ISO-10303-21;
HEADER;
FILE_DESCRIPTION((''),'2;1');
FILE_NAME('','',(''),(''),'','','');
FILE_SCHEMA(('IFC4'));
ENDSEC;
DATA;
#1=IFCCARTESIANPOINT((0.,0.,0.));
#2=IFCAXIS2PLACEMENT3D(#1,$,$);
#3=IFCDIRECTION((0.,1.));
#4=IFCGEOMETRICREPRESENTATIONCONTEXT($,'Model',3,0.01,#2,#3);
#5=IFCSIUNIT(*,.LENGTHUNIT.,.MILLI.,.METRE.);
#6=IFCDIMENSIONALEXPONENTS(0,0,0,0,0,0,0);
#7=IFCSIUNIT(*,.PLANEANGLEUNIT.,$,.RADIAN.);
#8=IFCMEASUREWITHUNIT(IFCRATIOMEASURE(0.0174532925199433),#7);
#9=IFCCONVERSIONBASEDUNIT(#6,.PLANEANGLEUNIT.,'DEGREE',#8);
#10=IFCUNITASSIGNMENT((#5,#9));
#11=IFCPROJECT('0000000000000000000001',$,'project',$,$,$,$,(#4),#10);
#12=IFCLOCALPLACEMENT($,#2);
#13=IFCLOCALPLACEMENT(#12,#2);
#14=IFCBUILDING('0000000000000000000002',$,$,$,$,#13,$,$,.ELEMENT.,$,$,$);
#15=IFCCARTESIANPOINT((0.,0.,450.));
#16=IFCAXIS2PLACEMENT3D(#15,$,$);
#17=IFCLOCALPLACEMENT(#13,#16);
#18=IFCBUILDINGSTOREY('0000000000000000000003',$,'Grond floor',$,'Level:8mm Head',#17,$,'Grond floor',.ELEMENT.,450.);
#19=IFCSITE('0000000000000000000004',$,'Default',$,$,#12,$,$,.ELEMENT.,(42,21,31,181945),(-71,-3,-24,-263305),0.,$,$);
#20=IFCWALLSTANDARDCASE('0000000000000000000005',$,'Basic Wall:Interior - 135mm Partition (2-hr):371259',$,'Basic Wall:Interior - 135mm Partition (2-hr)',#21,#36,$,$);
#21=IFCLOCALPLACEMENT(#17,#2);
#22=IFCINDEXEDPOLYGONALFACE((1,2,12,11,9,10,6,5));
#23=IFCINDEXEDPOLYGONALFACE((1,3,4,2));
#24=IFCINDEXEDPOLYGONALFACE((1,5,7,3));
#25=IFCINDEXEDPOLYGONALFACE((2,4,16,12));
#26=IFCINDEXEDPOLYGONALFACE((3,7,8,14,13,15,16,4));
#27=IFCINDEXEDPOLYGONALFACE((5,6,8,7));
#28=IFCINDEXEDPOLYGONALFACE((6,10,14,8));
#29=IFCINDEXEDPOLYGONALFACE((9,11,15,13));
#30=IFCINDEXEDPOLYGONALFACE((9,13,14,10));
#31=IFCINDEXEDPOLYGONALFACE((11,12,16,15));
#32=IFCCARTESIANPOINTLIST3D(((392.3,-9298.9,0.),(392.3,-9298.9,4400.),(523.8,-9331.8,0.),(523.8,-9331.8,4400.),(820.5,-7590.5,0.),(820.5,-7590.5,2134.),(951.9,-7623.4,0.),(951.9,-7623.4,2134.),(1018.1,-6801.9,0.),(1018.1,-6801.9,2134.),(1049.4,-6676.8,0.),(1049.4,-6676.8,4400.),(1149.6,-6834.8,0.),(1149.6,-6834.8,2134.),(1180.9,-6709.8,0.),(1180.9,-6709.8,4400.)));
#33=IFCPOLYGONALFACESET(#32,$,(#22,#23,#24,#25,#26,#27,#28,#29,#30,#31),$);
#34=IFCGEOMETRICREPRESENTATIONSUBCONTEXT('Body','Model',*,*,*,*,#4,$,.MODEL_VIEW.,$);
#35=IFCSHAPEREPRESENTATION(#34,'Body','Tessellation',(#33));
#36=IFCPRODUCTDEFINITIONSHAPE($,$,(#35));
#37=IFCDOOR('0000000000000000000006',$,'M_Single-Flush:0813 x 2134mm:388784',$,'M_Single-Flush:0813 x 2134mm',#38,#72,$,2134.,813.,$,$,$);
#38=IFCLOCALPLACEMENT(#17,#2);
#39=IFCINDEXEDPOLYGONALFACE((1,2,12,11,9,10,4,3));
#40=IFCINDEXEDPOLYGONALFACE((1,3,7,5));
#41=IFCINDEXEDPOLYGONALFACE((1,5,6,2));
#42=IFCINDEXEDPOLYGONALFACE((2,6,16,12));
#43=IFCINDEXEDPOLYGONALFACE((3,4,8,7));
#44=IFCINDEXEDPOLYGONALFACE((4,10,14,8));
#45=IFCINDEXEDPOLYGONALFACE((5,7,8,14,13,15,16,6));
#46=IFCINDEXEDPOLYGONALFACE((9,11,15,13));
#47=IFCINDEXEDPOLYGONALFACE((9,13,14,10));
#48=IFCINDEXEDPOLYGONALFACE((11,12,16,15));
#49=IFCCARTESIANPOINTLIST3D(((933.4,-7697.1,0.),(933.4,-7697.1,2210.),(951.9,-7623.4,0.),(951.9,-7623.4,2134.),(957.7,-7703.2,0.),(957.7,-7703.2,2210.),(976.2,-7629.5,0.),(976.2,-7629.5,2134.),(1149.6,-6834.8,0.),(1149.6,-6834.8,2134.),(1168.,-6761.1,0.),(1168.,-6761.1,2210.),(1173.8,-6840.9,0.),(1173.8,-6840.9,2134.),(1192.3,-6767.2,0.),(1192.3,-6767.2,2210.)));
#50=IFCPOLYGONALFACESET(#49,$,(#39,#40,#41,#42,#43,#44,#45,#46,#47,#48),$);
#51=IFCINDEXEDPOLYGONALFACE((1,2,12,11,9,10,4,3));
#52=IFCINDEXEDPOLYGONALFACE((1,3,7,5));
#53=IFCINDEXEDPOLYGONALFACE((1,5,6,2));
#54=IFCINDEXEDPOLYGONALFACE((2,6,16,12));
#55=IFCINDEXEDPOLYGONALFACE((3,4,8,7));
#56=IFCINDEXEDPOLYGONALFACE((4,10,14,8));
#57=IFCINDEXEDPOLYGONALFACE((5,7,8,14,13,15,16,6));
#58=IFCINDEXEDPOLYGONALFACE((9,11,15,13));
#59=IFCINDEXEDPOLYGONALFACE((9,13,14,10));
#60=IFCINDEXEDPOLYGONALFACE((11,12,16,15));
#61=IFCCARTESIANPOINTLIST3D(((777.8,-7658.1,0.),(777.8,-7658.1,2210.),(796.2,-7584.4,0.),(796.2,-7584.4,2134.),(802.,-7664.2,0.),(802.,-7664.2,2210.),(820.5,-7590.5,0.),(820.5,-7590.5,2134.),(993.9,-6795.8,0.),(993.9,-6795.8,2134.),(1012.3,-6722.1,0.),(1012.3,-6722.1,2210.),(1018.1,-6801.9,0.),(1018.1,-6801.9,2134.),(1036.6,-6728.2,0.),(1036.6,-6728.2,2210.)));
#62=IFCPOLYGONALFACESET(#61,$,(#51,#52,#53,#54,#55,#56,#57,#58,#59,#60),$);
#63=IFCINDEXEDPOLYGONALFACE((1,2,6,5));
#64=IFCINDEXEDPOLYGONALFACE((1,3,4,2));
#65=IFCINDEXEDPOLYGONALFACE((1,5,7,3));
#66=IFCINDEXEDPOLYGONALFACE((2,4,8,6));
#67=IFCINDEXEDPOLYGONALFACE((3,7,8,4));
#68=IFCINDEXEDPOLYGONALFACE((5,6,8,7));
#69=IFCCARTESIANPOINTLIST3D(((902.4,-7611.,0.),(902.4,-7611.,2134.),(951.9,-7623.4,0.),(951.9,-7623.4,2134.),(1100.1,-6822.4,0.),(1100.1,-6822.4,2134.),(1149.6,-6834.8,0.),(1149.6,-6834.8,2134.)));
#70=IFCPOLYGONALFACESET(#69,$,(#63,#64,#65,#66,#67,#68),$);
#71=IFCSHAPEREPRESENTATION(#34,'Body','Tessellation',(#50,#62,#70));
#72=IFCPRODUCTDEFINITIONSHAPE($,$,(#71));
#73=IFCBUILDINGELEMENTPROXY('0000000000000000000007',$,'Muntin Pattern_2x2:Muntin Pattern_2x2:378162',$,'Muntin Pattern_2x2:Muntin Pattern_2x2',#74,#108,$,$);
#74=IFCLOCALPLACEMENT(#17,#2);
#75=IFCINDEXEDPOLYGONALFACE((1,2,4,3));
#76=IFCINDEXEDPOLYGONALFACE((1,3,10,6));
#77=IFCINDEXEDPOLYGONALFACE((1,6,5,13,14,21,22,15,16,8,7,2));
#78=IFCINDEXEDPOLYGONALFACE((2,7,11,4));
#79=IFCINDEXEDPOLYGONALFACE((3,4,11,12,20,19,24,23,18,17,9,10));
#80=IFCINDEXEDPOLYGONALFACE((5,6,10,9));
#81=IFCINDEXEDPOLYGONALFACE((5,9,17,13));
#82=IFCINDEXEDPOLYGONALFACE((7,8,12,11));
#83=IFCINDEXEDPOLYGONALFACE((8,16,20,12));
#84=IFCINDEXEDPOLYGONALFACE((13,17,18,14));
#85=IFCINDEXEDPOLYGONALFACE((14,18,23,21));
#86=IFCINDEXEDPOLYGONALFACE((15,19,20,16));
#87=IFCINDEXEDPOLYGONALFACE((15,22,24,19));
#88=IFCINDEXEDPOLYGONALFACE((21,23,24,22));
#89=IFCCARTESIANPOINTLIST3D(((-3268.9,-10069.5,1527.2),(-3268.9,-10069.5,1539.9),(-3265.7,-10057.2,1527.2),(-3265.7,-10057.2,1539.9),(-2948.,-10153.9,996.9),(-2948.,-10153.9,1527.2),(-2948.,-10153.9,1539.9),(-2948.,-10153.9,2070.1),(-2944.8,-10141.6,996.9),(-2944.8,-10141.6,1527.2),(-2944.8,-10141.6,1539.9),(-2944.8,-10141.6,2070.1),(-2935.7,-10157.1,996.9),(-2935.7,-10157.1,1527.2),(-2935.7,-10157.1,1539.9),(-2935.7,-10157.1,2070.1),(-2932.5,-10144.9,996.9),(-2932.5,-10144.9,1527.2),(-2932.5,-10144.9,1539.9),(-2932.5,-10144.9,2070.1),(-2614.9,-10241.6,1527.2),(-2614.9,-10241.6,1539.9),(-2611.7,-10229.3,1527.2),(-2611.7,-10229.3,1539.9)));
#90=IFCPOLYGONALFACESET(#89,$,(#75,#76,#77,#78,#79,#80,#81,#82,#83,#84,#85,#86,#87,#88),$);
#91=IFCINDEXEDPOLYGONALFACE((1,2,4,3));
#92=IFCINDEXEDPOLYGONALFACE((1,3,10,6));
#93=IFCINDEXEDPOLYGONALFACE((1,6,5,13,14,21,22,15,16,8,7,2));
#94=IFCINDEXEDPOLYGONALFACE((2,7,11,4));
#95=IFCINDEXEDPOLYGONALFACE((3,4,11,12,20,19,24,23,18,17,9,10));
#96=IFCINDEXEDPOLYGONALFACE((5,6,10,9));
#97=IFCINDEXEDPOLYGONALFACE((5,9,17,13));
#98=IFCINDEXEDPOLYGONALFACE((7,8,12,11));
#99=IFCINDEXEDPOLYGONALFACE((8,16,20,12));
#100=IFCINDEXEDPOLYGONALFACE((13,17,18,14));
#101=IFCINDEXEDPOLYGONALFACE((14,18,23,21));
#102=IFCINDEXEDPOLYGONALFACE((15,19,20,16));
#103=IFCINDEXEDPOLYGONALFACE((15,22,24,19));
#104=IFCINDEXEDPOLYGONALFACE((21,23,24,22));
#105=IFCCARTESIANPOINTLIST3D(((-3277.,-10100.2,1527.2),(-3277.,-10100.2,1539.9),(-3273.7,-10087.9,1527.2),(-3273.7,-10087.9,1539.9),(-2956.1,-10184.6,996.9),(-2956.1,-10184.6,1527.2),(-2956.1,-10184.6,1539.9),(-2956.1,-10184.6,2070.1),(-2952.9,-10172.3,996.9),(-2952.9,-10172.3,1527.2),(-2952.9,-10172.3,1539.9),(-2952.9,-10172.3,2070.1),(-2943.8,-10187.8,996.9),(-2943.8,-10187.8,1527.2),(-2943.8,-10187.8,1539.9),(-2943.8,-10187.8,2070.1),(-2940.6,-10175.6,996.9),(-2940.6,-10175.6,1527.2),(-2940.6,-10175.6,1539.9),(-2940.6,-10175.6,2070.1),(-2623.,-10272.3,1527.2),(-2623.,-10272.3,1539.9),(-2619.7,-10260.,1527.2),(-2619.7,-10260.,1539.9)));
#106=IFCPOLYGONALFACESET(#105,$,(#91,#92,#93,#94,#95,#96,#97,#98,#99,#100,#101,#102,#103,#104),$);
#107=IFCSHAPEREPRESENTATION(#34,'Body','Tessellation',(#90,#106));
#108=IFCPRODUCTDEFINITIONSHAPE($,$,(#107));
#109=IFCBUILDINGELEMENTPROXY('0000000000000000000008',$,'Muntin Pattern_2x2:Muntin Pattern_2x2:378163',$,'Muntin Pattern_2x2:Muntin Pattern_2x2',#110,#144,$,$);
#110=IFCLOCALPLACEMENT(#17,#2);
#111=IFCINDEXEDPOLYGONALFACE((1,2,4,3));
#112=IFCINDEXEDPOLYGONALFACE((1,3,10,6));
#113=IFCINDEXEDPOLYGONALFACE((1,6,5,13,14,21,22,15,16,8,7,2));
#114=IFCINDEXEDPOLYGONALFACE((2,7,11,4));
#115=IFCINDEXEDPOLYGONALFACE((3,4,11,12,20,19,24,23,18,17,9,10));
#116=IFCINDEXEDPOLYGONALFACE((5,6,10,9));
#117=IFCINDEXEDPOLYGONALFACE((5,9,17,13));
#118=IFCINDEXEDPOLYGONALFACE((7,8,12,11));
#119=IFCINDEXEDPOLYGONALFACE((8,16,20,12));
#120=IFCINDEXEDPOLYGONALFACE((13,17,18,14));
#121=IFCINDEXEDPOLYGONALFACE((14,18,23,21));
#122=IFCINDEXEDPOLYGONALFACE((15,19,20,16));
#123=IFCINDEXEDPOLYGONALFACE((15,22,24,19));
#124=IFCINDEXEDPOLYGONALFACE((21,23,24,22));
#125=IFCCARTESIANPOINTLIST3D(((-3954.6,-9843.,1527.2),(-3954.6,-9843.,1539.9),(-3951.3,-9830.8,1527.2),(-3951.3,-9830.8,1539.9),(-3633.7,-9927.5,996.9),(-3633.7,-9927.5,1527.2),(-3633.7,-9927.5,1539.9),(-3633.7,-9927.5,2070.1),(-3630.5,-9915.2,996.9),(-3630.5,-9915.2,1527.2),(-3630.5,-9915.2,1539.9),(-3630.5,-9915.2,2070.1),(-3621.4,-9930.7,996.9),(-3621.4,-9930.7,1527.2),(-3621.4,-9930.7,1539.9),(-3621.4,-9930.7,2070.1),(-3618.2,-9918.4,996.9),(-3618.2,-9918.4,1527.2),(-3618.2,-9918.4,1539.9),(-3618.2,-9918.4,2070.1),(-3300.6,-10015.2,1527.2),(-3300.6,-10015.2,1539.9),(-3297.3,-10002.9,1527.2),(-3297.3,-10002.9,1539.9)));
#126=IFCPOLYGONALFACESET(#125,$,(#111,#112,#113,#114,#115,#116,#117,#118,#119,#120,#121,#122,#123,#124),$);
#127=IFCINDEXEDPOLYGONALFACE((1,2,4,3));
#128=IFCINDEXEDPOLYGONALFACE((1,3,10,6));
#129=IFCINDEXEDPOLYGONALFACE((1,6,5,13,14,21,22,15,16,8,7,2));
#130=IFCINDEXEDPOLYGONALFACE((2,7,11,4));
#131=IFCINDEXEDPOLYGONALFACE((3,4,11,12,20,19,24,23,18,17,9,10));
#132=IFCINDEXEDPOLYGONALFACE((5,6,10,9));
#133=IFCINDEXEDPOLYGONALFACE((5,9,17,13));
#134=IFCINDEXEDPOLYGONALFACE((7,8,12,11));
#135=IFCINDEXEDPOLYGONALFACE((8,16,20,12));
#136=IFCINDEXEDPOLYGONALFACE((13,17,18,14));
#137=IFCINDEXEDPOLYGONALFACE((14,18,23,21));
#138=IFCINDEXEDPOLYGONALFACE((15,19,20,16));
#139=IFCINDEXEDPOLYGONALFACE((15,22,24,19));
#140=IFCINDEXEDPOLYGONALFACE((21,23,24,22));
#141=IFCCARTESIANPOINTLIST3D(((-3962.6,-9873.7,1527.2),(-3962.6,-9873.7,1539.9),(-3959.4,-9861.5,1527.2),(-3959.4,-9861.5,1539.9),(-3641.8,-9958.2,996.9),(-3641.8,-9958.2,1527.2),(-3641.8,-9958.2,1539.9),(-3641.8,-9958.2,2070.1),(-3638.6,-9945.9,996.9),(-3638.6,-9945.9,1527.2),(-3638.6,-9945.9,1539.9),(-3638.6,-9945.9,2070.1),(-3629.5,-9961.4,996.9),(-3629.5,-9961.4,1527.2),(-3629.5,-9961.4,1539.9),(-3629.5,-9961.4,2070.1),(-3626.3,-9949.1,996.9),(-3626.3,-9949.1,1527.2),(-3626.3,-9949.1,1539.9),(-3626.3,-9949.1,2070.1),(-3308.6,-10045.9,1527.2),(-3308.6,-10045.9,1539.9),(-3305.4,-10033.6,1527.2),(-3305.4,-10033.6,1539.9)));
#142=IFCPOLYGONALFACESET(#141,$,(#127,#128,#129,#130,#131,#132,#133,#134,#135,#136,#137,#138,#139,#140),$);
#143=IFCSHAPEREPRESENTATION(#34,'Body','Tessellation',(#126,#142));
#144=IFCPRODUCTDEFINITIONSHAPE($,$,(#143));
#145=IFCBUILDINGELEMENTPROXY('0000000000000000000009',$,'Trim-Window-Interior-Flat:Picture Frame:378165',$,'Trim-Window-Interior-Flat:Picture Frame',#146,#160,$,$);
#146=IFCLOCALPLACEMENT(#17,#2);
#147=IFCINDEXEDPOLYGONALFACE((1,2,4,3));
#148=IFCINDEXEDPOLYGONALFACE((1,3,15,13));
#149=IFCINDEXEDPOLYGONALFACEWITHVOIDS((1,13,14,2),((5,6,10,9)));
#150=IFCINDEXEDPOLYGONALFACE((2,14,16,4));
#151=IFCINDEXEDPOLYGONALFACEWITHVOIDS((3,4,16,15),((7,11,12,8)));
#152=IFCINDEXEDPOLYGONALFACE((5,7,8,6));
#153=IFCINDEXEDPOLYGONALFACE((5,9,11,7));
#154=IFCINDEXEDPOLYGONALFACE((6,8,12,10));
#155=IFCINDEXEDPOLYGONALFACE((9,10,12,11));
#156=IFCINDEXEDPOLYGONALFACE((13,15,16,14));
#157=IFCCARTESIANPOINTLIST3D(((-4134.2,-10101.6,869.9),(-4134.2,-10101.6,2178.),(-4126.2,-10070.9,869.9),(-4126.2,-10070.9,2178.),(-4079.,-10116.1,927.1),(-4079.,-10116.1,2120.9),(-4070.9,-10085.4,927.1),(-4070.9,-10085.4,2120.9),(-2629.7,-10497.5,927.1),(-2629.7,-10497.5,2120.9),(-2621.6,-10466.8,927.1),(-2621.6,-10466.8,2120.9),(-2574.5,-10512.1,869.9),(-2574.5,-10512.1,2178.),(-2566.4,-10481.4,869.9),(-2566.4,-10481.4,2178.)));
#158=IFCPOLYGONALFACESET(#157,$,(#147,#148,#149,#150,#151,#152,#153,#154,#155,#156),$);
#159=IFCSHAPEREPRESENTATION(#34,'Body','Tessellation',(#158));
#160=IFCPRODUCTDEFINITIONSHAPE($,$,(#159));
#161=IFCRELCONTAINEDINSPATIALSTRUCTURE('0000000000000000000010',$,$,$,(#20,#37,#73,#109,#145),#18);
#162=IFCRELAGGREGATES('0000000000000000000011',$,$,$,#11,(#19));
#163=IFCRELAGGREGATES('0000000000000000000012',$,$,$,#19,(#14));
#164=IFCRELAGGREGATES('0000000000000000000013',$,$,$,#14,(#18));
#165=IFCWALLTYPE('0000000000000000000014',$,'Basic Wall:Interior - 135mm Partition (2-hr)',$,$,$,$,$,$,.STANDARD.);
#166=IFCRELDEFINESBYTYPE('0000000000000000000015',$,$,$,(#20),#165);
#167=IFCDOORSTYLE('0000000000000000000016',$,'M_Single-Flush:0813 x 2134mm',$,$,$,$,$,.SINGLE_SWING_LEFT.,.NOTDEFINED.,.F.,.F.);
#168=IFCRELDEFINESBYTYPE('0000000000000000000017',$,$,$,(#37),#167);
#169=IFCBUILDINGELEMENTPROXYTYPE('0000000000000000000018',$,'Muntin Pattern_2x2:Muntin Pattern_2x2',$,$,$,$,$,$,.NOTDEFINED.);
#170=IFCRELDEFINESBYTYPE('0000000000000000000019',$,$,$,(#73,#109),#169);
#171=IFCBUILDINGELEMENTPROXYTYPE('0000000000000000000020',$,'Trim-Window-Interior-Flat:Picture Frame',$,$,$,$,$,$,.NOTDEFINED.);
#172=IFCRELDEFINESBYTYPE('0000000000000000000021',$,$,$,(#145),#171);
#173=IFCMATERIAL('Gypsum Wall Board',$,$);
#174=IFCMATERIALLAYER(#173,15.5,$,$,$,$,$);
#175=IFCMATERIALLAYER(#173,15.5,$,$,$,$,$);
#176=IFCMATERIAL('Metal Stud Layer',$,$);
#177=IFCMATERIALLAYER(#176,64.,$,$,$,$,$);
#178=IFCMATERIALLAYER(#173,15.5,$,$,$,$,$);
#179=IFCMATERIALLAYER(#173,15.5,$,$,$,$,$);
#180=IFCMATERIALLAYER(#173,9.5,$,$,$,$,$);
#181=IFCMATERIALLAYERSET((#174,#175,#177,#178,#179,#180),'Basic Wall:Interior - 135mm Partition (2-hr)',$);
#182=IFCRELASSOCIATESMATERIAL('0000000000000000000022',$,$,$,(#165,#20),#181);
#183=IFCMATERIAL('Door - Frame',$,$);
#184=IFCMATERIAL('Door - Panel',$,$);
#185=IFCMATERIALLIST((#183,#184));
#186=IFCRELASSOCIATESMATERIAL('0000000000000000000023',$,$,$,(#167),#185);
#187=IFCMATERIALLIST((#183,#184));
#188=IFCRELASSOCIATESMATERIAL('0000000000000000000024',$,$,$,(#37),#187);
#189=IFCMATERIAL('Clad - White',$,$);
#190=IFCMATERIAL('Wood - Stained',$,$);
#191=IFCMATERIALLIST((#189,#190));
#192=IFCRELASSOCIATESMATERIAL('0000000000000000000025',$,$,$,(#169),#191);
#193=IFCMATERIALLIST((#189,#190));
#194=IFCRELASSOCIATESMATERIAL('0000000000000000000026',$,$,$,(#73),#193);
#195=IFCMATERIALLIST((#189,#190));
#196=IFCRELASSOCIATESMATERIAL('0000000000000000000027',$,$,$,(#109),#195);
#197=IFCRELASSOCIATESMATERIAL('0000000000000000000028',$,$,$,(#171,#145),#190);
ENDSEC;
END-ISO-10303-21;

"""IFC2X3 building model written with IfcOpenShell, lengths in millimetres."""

from ifc_helpers import new_model, entity, si_unit, converted_unit, direction, frame, frame_2d, origin, place, context, subcontext, project, spatial, polyline, rectangle, outline, extrude, source, transform, mapped, material, material_list, layer, layer_set, layer_usage, type_object, type_shapes, element, fill, save


model = new_model("IFC2X3")

# Units and contexts
model_context = context("Model", 3, precision=0.01, world=origin(), true_north=direction((0.0, 1.0)))
body_context = subcontext(model_context, "Body", "Model", "MODEL_VIEW")
ifc_project = project(units=[si_unit("LENGTHUNIT", "METRE", prefix="MILLI"), converted_unit("PLANEANGLEUNIT", "DEGREE", entity("IfcRatioMeasure", 0.0174532925199433), si_unit("PLANEANGLEUNIT", "RADIAN"), dimensions=[0, 0, 0, 0, 0, 0, 0])], contexts=[model_context])

# Site, building, storey
site_placement = place(None, origin())
site = spatial("IfcSite", under=ifc_project, at=site_placement, Name="Default", CompositionType="ELEMENT", RefLatitude=(42, 21, 31, 181945), RefLongitude=(-71, -3, -24, -263305), RefElevation=0.0)
building_placement = place(site_placement, origin())
building = spatial("IfcBuilding", under=site, at=building_placement, CompositionType="ELEMENT")
storey_placement = place(building_placement, frame((0.0, 0.0, 450.0)))
storey = spatial("IfcBuildingStorey", under=building, at=storey_placement, Name="Grond floor", ObjectType="Level:8mm Head", LongName="Grond floor", CompositionType="ELEMENT", Elevation=450.0)

# Shared definitions
ifc_material_1 = material(Name="Gypsum Wall Board")
ifc_layer_1 = layer(ifc_material_1, 15.5)
ifc_layer_2 = layer(ifc_material_1, 15.5)
ifc_material_2 = material(Name="Metal Stud Layer")
ifc_layer_3 = layer(ifc_material_2, 64.0)
ifc_layer_4 = layer(ifc_material_1, 15.5)
ifc_layer_5 = layer(ifc_material_1, 15.5)
ifc_layer_6 = layer(ifc_material_1, 9.5)
ifc_layer_set = layer_set([ifc_layer_1, ifc_layer_2, ifc_layer_3, ifc_layer_4, ifc_layer_5, ifc_layer_6], Name="Basic Wall:Interior - 135mm Partition (2-hr)")
wall_type = type_object("IfcWallType", Name="Basic Wall:Interior - 135mm Partition (2-hr)", PredefinedType="STANDARD", material=ifc_layer_set)

# Shared definitions
ifc_material_3 = material(Name="Door - Frame")
ifc_material_4 = material(Name="Door - Panel")

# Wall, opening, door
ifc_layer_usage_1 = layer_usage(ifc_layer_set, "AXIS2", "NEGATIVE", 67.8)
wall_1_placement = place(storey_placement, frame((458.1, -9315.4, 0.0), z_axis=(0.0, 0.0, 1.0), x_axis=(0.243092, 0.970003, 0.0)))
wall_1 = element("IfcWallStandardCase", 1, at=wall_1_placement, inside=storey, type_object=wall_type, material=ifc_layer_usage_1, Name="Basic Wall:Interior - 135mm Partition (2-hr):371259", ObjectType="Basic Wall:Interior - 135mm Partition (2-hr)", context=body_context, shape_type="SweptSolid", body=[
    extrude(rectangle(XDim=2703.1, YDim=135.5, at=frame_2d((1351.6, 0.0), x_axis=(-1.0, 0.0))), origin(), (0.0, 0.0, 1.0), 4400.0),
])
opening_1_placement = place(wall_1_placement, frame((2574.2, 67.8, 0.0)))
opening_1 = element("IfcOpeningElement", 2, at=opening_1_placement, cuts=wall_1, ObjectType="Opening", context=body_context, shape_type="SweptSolid", body=[
    extrude(rectangle(XDim=813.0, YDim=2134.0, at=frame_2d((1067.0, 406.5), x_axis=(0.0, -1.0))), frame((0.0, 0.0, 0.0), z_axis=(0.0, -1.0, 0.0), x_axis=(0.0, 0.0, 1.0)), (0.0, 0.0, 1.0), 135.5),
])
ifc_material_list_1 = material_list([ifc_material_3, ifc_material_4])
ifc_material_list_2 = material_list([ifc_material_3, ifc_material_4])
door_style_1 = type_object("IfcDoorStyle", Name="M_Single-Flush:0813 x 2134mm", ConstructionType="NOTDEFINED", OperationType="SINGLE_SWING_LEFT", ParameterTakesPrecedence=False, Sizeable=False, material=ifc_material_list_2)
shared_shape_1 = source(origin(), body_context, "Body", "SweptSolid", [
    extrude(outline(polyline([(-482.5, -1124.0), (482.5, -1124.0), (482.5, 1086.0), (406.5, 1086.0), (406.5, -1048.0), (-406.5, -1048.0), (-406.5, 1086.0), (-482.5, 1086.0), (-482.5, -1124.0)])), frame((406.5, 160.5, 1086.0), z_axis=(0.0, -1.0, 0.0), x_axis=(-1.0, 0.0, 0.0)), (0.0, 0.0, 1.0), 25.0),
    extrude(outline(polyline([(-1124.0, -482.5), (1086.0, -482.5), (1086.0, -406.5), (-1048.0, -406.5), (-1048.0, 406.5), (1086.0, 406.5), (1086.0, 482.5), (-1124.0, 482.5), (-1124.0, -482.5)])), frame((406.5, 0.0, 1086.0), z_axis=(0.0, -1.0, 0.0), x_axis=(0.0, 0.0, -1.0)), (0.0, 0.0, 1.0), 25.0),
    extrude(rectangle(XDim=813.0, YDim=51.0, at=frame_2d((0.0, 0.0), x_axis=(1.0, 0.0))), frame((406.5, 110.0, 0.0)), (0.0, 0.0, 1.0), 2134.0),
])
type_shapes(door_style_1, [shared_shape_1])
door_1_placement = place(opening_1_placement, frame((0.0, 0.0, 0.0), z_axis=(0.0, 0.0, 1.0), x_axis=(-1.0, 0.0, 0.0)))
door_1 = element("IfcDoor", 3, at=door_1_placement, inside=storey, type_object=door_style_1, material=ifc_material_list_1, Name="M_Single-Flush:0813 x 2134mm:388784", ObjectType="M_Single-Flush:0813 x 2134mm", OverallHeight=2134.0, OverallWidth=813.0, context=body_context, shape_type="MappedRepresentation", body=[
    mapped(shared_shape_1, transform((0.0, 0.0, 0.0), scale=1.0)),
])
fill(opening_1, door_1)

# Building element proxies
ifc_material_5 = material(Name="Clad - White")
ifc_material_6 = material(Name="Wood - Stained")
ifc_material_list_3 = material_list([ifc_material_5, ifc_material_6])
ifc_material_list_4 = material_list([ifc_material_5, ifc_material_6])
building_element_proxy_type_1 = type_object("IfcBuildingElementProxyType", Name="Muntin Pattern_2x2:Muntin Pattern_2x2", PredefinedType="NOTDEFINED", material=ifc_material_list_4)
shared_shape_2 = source(origin(), body_context, "Body", "SweptSolid", [
    extrude(outline(polyline([(6.4, -6.4), (536.6, -6.4), (536.6, 6.3), (6.4, 6.3), (6.4, 338.1), (-6.3, 338.1), (-6.3, 6.3), (-536.6, 6.3), (-536.6, -6.4), (-6.3, -6.4), (-6.3, -338.1), (6.4, -338.1), (6.4, -6.4)])), frame((0.0, 9.5, 536.6), z_axis=(0.0, 1.0, 0.0), x_axis=(0.0, 0.0, 1.0)), (0.0, 0.0, 1.0), 12.7),
    extrude(outline(polyline([(6.4, -6.4), (536.6, -6.4), (536.6, 6.3), (6.4, 6.3), (6.4, 338.1), (-6.3, 338.1), (-6.3, 6.3), (-536.6, 6.3), (-536.6, -6.4), (-6.3, -6.4), (-6.3, -338.1), (6.4, -338.1), (6.4, -6.4)])), frame((0.0, -22.2, 536.6), z_axis=(0.0, 1.0, 0.0), x_axis=(0.0, 0.0, 1.0)), (0.0, 0.0, 1.0), 12.7),
])
type_shapes(building_element_proxy_type_1, [shared_shape_2])
proxy_1_placement = place(storey_placement, frame((-2944.3, -10164.7, 996.9), z_axis=(0.0, 0.0, 1.0), x_axis=(0.967067, -0.25452, 0.0)))
element("IfcBuildingElementProxy", 4, at=proxy_1_placement, inside=storey, type_object=building_element_proxy_type_1, material=ifc_material_list_3, Name="Muntin Pattern_2x2:Muntin Pattern_2x2:378162", ObjectType="Muntin Pattern_2x2:Muntin Pattern_2x2", context=body_context, shape_type="MappedRepresentation", body=[
    mapped(shared_shape_2, transform((0.0, 0.0, 0.0), scale=1.0)),
])
ifc_material_list_5 = material_list([ifc_material_5, ifc_material_6])
proxy_2_placement = place(storey_placement, frame((-3630.0, -9938.3, 996.9), z_axis=(0.0, 0.0, 1.0), x_axis=(0.967067, -0.25452, 0.0)))
element("IfcBuildingElementProxy", 5, at=proxy_2_placement, inside=storey, type_object=building_element_proxy_type_1, material=ifc_material_list_5, Name="Muntin Pattern_2x2:Muntin Pattern_2x2:378163", ObjectType="Muntin Pattern_2x2:Muntin Pattern_2x2", context=body_context, shape_type="MappedRepresentation", body=[
    mapped(shared_shape_2, transform((0.0, 0.0, 0.0), scale=1.0)),
])
building_element_proxy_type_2 = type_object("IfcBuildingElementProxyType", Name="Trim-Window-Interior-Flat:Picture Frame", PredefinedType="NOTDEFINED", material=ifc_material_6)
shared_shape_3 = source(origin(), body_context, "Body", "SweptSolid", [
    extrude(outline(polyline([(-806.4, -654.0), (806.4, -654.0), (806.4, 654.0), (-806.4, 654.0), (-806.4, -654.0)]), holes=[polyline([(-749.3, -596.9), (-749.3, 596.9), (749.3, 596.9), (749.3, -596.9), (-749.3, -596.9)])]), frame((0.0, -609.6, 0.0), z_axis=(0.0, 0.0, 1.0), x_axis=(-1.0, 0.0, 0.0)), (0.0, 0.0, 1.0), 31.8),
])
type_shapes(building_element_proxy_type_2, [shared_shape_3])
proxy_3_placement = place(storey_placement, frame((-3346.3, -10276.1, 2133.6), z_axis=(-0.25452, -0.967067, 0.0), x_axis=(0.967067, -0.25452, 0.0)))
element("IfcBuildingElementProxy", 6, at=proxy_3_placement, inside=storey, type_object=building_element_proxy_type_2, material=ifc_material_6, Name="Trim-Window-Interior-Flat:Picture Frame:378165", ObjectType="Trim-Window-Interior-Flat:Picture Frame", context=body_context, shape_type="MappedRepresentation", body=[
    mapped(shared_shape_3, transform((0.0, 0.0, 0.0), scale=1.0)),
])

save(model, "model.ifc")
